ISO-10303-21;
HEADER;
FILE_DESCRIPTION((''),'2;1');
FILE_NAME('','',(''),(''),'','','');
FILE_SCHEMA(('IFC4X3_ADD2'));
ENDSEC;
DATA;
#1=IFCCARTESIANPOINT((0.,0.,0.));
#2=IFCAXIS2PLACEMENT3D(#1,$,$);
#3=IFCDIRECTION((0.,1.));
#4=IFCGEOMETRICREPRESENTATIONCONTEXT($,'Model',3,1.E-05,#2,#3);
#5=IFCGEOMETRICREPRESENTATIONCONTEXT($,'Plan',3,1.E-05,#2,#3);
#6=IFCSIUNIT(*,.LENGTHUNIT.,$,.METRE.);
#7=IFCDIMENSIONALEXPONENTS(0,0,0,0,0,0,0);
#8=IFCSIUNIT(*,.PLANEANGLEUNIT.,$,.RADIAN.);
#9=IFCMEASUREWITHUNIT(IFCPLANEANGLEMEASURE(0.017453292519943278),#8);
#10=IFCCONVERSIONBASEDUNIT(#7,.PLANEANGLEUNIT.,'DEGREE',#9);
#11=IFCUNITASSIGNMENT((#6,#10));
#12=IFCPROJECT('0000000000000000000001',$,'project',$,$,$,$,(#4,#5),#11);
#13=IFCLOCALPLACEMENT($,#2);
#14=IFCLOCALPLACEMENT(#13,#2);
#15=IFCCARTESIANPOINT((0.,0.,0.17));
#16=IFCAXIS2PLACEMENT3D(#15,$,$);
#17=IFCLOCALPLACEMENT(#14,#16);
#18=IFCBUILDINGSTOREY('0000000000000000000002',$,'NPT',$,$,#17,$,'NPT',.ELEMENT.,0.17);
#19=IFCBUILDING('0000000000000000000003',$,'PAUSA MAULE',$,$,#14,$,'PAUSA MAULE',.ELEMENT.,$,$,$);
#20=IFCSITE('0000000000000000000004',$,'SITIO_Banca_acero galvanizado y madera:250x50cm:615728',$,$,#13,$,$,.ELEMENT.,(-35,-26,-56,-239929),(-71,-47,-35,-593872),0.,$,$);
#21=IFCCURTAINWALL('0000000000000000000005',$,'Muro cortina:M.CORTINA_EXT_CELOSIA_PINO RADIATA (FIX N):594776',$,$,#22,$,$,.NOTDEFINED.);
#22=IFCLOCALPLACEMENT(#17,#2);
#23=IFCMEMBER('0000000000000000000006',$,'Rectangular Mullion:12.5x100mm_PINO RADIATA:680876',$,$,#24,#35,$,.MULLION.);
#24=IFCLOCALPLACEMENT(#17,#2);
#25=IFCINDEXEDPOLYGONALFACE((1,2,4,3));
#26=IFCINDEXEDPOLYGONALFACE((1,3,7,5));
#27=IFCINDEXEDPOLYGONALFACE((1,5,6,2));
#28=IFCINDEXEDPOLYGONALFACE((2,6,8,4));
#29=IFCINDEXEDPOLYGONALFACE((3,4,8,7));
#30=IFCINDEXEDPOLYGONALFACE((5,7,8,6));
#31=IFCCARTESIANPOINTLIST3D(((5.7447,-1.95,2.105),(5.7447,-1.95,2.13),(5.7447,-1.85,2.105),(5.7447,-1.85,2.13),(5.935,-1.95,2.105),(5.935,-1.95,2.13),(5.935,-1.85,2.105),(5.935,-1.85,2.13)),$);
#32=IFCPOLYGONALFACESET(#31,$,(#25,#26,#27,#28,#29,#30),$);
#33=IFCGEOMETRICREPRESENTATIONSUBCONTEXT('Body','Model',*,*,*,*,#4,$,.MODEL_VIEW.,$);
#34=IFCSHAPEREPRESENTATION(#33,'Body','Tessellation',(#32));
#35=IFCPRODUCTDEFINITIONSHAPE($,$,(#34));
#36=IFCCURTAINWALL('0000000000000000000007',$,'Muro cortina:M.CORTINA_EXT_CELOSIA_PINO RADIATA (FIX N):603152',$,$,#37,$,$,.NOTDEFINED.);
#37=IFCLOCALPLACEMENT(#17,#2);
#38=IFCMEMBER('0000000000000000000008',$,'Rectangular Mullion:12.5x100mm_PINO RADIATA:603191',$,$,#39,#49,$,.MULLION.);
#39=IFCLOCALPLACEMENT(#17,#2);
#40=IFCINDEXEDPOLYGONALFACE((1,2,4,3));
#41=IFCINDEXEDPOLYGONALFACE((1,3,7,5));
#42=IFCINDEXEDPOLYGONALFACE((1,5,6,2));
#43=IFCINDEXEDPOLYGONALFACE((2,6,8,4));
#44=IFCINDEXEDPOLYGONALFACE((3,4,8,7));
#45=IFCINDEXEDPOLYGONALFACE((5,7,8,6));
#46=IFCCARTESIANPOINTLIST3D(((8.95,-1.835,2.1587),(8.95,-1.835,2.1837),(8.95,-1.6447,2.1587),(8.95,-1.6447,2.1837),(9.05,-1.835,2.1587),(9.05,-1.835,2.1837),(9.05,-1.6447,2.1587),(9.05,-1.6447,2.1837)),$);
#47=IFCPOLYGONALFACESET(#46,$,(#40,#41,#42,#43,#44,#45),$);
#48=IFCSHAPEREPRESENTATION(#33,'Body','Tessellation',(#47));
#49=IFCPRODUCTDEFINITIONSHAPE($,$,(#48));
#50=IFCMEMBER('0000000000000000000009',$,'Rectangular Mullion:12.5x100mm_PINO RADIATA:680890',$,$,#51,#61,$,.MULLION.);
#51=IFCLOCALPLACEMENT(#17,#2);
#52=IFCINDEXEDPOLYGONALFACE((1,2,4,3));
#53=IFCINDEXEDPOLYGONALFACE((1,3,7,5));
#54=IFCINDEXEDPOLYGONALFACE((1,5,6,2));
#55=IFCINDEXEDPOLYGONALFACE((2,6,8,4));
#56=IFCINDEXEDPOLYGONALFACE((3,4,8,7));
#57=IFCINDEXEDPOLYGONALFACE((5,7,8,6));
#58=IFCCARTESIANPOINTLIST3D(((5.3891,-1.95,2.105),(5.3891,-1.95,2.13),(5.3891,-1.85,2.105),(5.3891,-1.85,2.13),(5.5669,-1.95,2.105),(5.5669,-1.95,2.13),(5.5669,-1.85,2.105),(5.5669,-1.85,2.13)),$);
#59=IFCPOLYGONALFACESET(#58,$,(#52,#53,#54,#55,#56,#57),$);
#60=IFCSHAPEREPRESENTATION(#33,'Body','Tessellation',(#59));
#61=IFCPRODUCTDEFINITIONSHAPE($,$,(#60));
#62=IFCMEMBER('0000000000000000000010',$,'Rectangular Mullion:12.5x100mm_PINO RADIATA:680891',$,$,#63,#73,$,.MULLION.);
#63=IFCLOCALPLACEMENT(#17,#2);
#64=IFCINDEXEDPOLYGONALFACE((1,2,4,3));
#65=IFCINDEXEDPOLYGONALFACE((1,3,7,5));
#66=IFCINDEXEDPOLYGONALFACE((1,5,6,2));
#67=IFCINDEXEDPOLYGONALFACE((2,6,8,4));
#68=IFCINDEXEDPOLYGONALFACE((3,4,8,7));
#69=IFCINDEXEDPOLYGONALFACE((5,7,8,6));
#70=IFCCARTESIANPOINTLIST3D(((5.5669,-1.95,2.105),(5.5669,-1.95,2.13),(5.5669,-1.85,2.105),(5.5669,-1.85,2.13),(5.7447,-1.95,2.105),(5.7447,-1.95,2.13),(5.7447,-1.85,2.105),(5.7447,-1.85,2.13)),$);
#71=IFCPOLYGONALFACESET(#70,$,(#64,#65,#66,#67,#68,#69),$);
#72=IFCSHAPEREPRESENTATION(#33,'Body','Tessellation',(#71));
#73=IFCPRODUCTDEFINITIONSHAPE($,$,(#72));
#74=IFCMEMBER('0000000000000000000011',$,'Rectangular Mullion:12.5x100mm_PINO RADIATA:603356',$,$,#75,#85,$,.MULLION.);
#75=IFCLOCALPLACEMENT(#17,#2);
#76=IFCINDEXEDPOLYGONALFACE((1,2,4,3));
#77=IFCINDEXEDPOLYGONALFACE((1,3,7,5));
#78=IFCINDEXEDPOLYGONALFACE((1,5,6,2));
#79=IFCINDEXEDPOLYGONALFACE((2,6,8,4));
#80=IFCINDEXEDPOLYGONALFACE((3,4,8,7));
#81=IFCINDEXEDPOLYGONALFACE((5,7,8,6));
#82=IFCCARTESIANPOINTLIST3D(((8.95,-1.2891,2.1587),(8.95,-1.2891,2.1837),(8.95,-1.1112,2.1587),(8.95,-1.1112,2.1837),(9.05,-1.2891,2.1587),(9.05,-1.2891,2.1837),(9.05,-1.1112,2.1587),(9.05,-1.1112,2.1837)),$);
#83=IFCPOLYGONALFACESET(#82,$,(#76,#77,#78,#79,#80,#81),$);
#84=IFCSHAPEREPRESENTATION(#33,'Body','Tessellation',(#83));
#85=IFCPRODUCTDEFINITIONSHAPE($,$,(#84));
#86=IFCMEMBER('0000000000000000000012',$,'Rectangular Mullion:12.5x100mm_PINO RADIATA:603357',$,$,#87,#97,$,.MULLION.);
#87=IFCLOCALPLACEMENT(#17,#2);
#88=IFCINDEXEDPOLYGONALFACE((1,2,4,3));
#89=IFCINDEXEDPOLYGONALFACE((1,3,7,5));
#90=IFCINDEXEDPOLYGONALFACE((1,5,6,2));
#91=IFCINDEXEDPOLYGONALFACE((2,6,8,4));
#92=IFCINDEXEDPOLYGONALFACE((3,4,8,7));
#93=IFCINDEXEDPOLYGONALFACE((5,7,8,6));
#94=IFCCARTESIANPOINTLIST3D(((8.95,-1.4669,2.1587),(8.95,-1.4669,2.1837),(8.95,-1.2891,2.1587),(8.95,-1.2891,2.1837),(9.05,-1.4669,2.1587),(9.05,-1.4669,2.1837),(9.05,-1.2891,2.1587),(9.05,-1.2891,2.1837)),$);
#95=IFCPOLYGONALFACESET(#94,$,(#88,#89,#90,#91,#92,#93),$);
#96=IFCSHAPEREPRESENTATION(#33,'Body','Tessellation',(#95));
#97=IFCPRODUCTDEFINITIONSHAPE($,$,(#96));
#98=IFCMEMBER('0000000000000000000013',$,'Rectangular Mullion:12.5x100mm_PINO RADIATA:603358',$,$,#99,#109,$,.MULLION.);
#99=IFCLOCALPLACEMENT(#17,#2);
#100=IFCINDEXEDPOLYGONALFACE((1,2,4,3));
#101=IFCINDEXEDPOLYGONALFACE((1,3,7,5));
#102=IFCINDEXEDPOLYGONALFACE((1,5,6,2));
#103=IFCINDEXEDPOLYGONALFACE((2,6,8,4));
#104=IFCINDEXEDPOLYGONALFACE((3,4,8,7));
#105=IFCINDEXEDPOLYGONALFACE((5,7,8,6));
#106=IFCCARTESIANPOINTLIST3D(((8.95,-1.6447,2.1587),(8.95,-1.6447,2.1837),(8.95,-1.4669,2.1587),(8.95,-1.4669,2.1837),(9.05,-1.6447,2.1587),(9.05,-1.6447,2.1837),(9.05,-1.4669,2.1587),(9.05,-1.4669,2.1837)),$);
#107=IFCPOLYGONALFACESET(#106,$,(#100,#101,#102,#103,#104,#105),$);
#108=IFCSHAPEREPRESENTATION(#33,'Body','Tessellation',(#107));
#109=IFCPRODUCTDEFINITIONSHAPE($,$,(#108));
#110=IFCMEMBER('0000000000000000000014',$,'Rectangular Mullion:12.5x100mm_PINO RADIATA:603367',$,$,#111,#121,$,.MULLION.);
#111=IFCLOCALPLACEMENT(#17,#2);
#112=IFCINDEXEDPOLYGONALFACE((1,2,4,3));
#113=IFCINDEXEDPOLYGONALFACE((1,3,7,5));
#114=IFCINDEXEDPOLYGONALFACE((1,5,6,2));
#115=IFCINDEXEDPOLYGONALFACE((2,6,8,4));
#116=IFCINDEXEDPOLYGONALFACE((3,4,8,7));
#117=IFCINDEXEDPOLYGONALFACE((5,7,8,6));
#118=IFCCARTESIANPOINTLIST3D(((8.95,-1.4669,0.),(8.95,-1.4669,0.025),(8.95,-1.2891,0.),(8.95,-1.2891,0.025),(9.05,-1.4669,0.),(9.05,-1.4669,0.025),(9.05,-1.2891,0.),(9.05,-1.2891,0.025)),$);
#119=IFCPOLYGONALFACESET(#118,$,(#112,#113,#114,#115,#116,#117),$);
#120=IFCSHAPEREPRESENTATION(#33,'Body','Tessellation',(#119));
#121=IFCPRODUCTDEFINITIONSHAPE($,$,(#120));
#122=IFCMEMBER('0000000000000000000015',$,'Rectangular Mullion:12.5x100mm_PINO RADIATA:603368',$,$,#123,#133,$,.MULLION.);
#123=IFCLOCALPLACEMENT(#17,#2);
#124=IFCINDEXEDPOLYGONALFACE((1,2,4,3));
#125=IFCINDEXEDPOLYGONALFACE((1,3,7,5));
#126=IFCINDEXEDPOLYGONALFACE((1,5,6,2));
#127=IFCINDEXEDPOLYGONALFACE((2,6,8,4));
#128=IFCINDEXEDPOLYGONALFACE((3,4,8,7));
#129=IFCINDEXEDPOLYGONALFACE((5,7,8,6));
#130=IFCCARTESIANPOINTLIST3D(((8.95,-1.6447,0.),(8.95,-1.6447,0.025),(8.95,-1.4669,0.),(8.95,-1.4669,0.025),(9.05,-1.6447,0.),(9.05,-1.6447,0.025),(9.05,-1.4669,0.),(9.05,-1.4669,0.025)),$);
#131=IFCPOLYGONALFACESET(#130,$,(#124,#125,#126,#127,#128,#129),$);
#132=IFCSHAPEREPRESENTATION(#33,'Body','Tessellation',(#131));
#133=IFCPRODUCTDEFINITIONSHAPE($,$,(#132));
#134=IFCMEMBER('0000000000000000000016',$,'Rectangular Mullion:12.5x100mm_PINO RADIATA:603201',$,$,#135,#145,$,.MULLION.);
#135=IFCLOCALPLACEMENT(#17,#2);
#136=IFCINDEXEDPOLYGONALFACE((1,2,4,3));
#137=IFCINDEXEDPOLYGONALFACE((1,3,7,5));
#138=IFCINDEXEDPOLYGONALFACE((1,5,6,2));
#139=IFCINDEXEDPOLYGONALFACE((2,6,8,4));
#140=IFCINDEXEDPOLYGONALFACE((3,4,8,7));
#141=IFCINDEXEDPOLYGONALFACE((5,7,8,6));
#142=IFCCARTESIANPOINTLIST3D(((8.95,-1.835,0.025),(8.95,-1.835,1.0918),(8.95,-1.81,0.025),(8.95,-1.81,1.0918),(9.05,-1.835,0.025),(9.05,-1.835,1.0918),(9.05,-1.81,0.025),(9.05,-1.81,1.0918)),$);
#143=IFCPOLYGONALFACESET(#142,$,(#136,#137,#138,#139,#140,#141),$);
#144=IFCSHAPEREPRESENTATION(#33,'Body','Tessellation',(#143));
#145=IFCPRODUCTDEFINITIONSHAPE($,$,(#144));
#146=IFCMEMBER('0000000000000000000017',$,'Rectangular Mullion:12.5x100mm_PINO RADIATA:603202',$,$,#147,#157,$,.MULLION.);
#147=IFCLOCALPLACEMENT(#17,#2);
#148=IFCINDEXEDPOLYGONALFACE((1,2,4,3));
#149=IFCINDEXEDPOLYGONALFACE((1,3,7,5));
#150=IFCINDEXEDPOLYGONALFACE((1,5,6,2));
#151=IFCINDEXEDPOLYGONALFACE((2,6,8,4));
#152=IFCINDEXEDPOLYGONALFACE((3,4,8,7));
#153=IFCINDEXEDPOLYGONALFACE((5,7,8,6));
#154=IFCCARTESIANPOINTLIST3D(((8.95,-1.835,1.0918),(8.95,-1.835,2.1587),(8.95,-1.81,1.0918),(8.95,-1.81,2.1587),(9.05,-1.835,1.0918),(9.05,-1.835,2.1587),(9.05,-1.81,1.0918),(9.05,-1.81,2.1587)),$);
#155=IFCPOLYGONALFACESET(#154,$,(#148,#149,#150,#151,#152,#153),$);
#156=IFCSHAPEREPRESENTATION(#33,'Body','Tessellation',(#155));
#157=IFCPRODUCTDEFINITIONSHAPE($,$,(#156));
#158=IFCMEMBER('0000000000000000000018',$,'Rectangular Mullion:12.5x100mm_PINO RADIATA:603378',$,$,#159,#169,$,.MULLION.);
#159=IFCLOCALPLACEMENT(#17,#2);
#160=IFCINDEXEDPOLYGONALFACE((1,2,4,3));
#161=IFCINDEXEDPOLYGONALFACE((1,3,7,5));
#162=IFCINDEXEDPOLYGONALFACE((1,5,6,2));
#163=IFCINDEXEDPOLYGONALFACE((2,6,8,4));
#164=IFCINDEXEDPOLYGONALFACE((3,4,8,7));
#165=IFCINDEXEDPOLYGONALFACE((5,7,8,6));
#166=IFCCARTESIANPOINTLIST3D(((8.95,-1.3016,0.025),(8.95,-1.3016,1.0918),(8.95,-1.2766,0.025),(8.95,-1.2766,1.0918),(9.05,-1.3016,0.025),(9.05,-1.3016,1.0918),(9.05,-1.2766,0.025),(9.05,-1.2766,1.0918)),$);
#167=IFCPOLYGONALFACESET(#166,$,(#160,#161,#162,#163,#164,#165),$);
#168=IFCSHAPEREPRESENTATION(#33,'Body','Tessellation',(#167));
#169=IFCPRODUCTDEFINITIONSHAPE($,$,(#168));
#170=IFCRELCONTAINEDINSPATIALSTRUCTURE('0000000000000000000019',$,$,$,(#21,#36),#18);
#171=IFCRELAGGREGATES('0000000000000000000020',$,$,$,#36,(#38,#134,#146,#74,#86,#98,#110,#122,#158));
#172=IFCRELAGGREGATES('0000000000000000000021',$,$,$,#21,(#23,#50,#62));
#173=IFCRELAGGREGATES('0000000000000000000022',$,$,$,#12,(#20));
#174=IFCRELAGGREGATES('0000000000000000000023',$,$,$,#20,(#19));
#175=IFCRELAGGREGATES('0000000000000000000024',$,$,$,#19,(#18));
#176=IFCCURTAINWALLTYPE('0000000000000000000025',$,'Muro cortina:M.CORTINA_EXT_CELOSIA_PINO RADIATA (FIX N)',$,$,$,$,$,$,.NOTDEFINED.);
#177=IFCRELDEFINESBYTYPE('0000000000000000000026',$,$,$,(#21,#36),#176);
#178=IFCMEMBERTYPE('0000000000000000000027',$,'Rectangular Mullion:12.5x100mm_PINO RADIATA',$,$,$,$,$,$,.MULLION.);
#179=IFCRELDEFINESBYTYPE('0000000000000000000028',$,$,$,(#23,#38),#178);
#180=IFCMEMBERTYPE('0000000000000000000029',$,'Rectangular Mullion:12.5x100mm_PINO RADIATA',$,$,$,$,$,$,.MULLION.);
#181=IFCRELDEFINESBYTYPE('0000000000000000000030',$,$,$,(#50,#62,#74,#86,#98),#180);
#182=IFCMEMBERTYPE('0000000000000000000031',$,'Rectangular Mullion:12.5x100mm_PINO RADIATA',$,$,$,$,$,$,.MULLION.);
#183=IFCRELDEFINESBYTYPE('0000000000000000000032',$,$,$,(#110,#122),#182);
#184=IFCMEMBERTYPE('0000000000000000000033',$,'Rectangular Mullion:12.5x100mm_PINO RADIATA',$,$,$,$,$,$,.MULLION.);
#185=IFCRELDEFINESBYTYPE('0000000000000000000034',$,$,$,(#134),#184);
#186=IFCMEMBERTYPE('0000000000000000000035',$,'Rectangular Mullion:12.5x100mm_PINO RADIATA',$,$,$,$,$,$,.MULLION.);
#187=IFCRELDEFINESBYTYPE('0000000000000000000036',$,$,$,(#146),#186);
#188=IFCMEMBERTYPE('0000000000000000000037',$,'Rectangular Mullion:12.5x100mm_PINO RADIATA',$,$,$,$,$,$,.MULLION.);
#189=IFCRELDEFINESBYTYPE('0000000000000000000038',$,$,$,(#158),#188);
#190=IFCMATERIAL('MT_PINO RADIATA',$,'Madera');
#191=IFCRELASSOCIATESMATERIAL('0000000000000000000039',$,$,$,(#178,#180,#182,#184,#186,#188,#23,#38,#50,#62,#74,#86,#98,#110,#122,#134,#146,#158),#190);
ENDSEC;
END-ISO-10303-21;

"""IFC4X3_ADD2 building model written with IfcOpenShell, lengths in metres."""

from ifc_helpers import new_model, entity, si_unit, converted_unit, direction, frame, frame_2d, origin, origin_2d_with_axis, place, context, subcontext, project, spatial, rectangle, extrude, source, transform, mapped, material, material_profile, profile_set, profile_usage, type_object, type_shapes, element, aggregate, save


model = new_model("IFC4X3_ADD2")

# Units and contexts
model_context = context("Model", 3, precision=1e-05, world=origin(), true_north=direction((0.0, 1.0)))
plan_context = context("Plan", 3, precision=1e-05, world=origin(), true_north=direction((0.0, 1.0)))
body_context = subcontext(model_context, "Body", "Model", "MODEL_VIEW")
ifc_project = project(units=[si_unit("LENGTHUNIT", "METRE"), converted_unit("PLANEANGLEUNIT", "DEGREE", entity("IfcPlaneAngleMeasure", 0.017453292519943278), si_unit("PLANEANGLEUNIT", "RADIAN"), dimensions=[0, 0, 0, 0, 0, 0, 0])], contexts=[model_context, plan_context])

# Site, building, storey
site_placement = place(None, origin())
site = spatial("IfcSite", under=ifc_project, at=site_placement, Name="SITIO_Banca_acero galvanizado y madera:250x50cm:615728", CompositionType="ELEMENT", RefLatitude=(-35, -26, -56, -239929), RefLongitude=(-71, -47, -35, -593872), RefElevation=0.0)
building_placement = place(site_placement, origin())
building = spatial("IfcBuilding", under=site, at=building_placement, Name="PAUSA MAULE", LongName="PAUSA MAULE", CompositionType="ELEMENT")
storey_placement = place(building_placement, frame((0.0, 0.0, 0.17)))
storey = spatial("IfcBuildingStorey", under=building, at=storey_placement, Name="NPT", LongName="NPT", CompositionType="ELEMENT", Elevation=0.17)

# Curtain walls, members
curtain_wall_type = type_object("IfcCurtainWallType", Name="Muro cortina:M.CORTINA_EXT_CELOSIA_PINO RADIATA (FIX N)", PredefinedType="NOTDEFINED")
curtain_wall_1_placement = place(storey_placement, frame((0.0, 0.0, -0.17)))
curtain_wall_1 = element("IfcCurtainWall", 1, at=curtain_wall_1_placement, inside=storey, type_object=curtain_wall_type, Name="Muro cortina:M.CORTINA_EXT_CELOSIA_PINO RADIATA (FIX N):594776", PredefinedType="NOTDEFINED")
ifc_material = material(Name="MT_PINO RADIATA", Category="Madera")
ifc_material_profile = material_profile(ifc_material, rectangle(XDim=0.025, YDim=0.1, at=frame_2d((0.0, 0.0), x_axis=(1.0, 0.0))), Name="12.5x100mm_PINO RADIATA")
ifc_profile_set = profile_set([ifc_material_profile], Name="12.5x100mm_PINO RADIATA")
ifc_profile_usage = profile_usage(ifc_profile_set)
member_type_1 = type_object("IfcMemberType", Name="Rectangular Mullion:12.5x100mm_PINO RADIATA", PredefinedType="MULLION", material=ifc_profile_set)
shared_shape_1 = source(origin(), body_context, "Body", "SweptSolid", [
    extrude(rectangle(XDim=0.025, YDim=0.1, at=frame_2d((0.0, 0.0), x_axis=(1.0, 0.0))), frame((-0.0125, 0.0, -0.1903), z_axis=(0.0, 0.0, 1.0), x_axis=(-1.0, 0.0, 0.0)), (0.0, 0.0, 1.0), 0.1903),
])
type_shapes(member_type_1, [shared_shape_1])
member_1_placement = place(curtain_wall_1_placement, frame((5.935, -1.9, 2.3), z_axis=(1.0, 0.0, 0.0), x_axis=(0.0, 0.0, 1.0)))
member_1 = element("IfcMember", 2, at=member_1_placement, type_object=member_type_1, material=ifc_profile_usage, Name="Rectangular Mullion:12.5x100mm_PINO RADIATA:680876", PredefinedType="MULLION", context=body_context, shape_type="MappedRepresentation", body=[
    mapped(shared_shape_1, transform((0.0, 0.0, 0.0), scale=1.0)),
])
curtain_wall_2_placement = place(storey_placement, frame((0.0, 0.0, -0.17)))
curtain_wall_2 = element("IfcCurtainWall", 3, at=curtain_wall_2_placement, inside=storey, type_object=curtain_wall_type, Name="Muro cortina:M.CORTINA_EXT_CELOSIA_PINO RADIATA (FIX N):603152", PredefinedType="NOTDEFINED")
member_2_placement = place(curtain_wall_2_placement, frame((9.0, -1.835, 2.3537), z_axis=(0.0, -1.0, 0.0), x_axis=(0.0, 0.0, 1.0)))
member_2 = element("IfcMember", 4, at=member_2_placement, type_object=member_type_1, material=ifc_profile_usage, Name="Rectangular Mullion:12.5x100mm_PINO RADIATA:603191", PredefinedType="MULLION", context=body_context, shape_type="MappedRepresentation", body=[
    mapped(shared_shape_1, transform((0.0, 0.0, 0.0), scale=1.0)),
])

# Members
member_type_2 = type_object("IfcMemberType", Name="Rectangular Mullion:12.5x100mm_PINO RADIATA", PredefinedType="MULLION", material=ifc_profile_set)
shared_shape_2 = source(origin(), body_context, "Body", "SweptSolid", [
    extrude(rectangle(XDim=0.025, YDim=0.1, at=frame_2d((0.0, 0.0), x_axis=(1.0, 0.0))), frame((-0.0125, 0.0, -0.1778), z_axis=(0.0, 0.0, 1.0), x_axis=(-1.0, 0.0, 0.0)), (0.0, 0.0, 1.0), 0.1778),
])
type_shapes(member_type_2, [shared_shape_2])
member_3_placement = place(curtain_wall_1_placement, frame((5.5669, -1.9, 2.3), z_axis=(1.0, 0.0, 0.0), x_axis=(0.0, 0.0, 1.0)))
member_3 = element("IfcMember", 5, at=member_3_placement, type_object=member_type_2, material=ifc_profile_usage, Name="Rectangular Mullion:12.5x100mm_PINO RADIATA:680890", PredefinedType="MULLION", context=body_context, shape_type="MappedRepresentation", body=[
    mapped(shared_shape_2, transform((0.0, 0.0, 0.0), scale=1.0)),
])
member_4_placement = place(curtain_wall_1_placement, frame((5.7447, -1.9, 2.3), z_axis=(1.0, 0.0, 0.0), x_axis=(0.0, 0.0, 1.0)))
member_4 = element("IfcMember", 6, at=member_4_placement, type_object=member_type_2, material=ifc_profile_usage, Name="Rectangular Mullion:12.5x100mm_PINO RADIATA:680891", PredefinedType="MULLION", context=body_context, shape_type="MappedRepresentation", body=[
    mapped(shared_shape_2, transform((0.0, 0.0, 0.0), scale=1.0)),
])
member_5_placement = place(curtain_wall_2_placement, frame((9.0, -1.2891, 2.3537), z_axis=(0.0, -1.0, 0.0), x_axis=(0.0, 0.0, 1.0)))
member_5 = element("IfcMember", 7, at=member_5_placement, type_object=member_type_2, material=ifc_profile_usage, Name="Rectangular Mullion:12.5x100mm_PINO RADIATA:603356", PredefinedType="MULLION", context=body_context, shape_type="MappedRepresentation", body=[
    mapped(shared_shape_2, transform((0.0, 0.0, 0.0), scale=1.0)),
])
member_6_placement = place(curtain_wall_2_placement, frame((9.0, -1.4669, 2.3537), z_axis=(0.0, -1.0, 0.0), x_axis=(0.0, 0.0, 1.0)))
member_6 = element("IfcMember", 8, at=member_6_placement, type_object=member_type_2, material=ifc_profile_usage, Name="Rectangular Mullion:12.5x100mm_PINO RADIATA:603357", PredefinedType="MULLION", context=body_context, shape_type="MappedRepresentation", body=[
    mapped(shared_shape_2, transform((0.0, 0.0, 0.0), scale=1.0)),
])
member_7_placement = place(curtain_wall_2_placement, frame((9.0, -1.6447, 2.3537), z_axis=(0.0, -1.0, 0.0), x_axis=(0.0, 0.0, 1.0)))
member_7 = element("IfcMember", 9, at=member_7_placement, type_object=member_type_2, material=ifc_profile_usage, Name="Rectangular Mullion:12.5x100mm_PINO RADIATA:603358", PredefinedType="MULLION", context=body_context, shape_type="MappedRepresentation", body=[
    mapped(shared_shape_2, transform((0.0, 0.0, 0.0), scale=1.0)),
])
member_type_3 = type_object("IfcMemberType", Name="Rectangular Mullion:12.5x100mm_PINO RADIATA", PredefinedType="MULLION", material=ifc_profile_set)
shared_shape_3 = source(origin(), body_context, "Body", "SweptSolid", [
    extrude(rectangle(XDim=0.025, YDim=0.1, at=frame_2d((0.0, 0.0), x_axis=(1.0, 0.0))), frame((-0.0125, 0.0, -0.1778), z_axis=(0.0, 0.0, 1.0), x_axis=(-1.0, 0.0, 0.0)), (0.0, 0.0, 1.0), 0.1778),
])
type_shapes(member_type_3, [shared_shape_3])
member_8_placement = place(curtain_wall_2_placement, frame((9.0, -1.2891, 0.17), z_axis=(0.0, 1.0, 0.0), x_axis=(0.0, 0.0, -1.0)))
member_8 = element("IfcMember", 10, at=member_8_placement, type_object=member_type_3, material=ifc_profile_usage, Name="Rectangular Mullion:12.5x100mm_PINO RADIATA:603367", PredefinedType="MULLION", context=body_context, shape_type="MappedRepresentation", body=[
    mapped(shared_shape_3, transform((0.0, 0.0, 0.0), scale=1.0)),
])
member_9_placement = place(curtain_wall_2_placement, frame((9.0, -1.4669, 0.17), z_axis=(0.0, 1.0, 0.0), x_axis=(0.0, 0.0, -1.0)))
member_9 = element("IfcMember", 11, at=member_9_placement, type_object=member_type_3, material=ifc_profile_usage, Name="Rectangular Mullion:12.5x100mm_PINO RADIATA:603368", PredefinedType="MULLION", context=body_context, shape_type="MappedRepresentation", body=[
    mapped(shared_shape_3, transform((0.0, 0.0, 0.0), scale=1.0)),
])
member_type_4 = type_object("IfcMemberType", Name="Rectangular Mullion:12.5x100mm_PINO RADIATA", PredefinedType="MULLION", material=ifc_profile_set)
shared_shape_4 = source(origin(), body_context, "Body", "SweptSolid", [
    extrude(rectangle(XDim=0.025, YDim=0.1, at=origin_2d_with_axis()), frame((-0.0125, 0.0, -1.0668), z_axis=(0.0, 0.0, 1.0), x_axis=(-1.0, 0.0, 0.0)), (0.0, 0.0, 1.0), 1.0668),
])
type_shapes(member_type_4, [shared_shape_4])
member_10_placement = place(curtain_wall_2_placement, frame((9.0, -1.835, 0.195), z_axis=(0.0, 0.0, -1.0), x_axis=(0.0, -1.0, 0.0)))
member_10 = element("IfcMember", 12, at=member_10_placement, type_object=member_type_4, material=ifc_profile_usage, Name="Rectangular Mullion:12.5x100mm_PINO RADIATA:603201", PredefinedType="MULLION", context=body_context, shape_type="MappedRepresentation", body=[
    mapped(shared_shape_4, transform((0.0, 0.0, 0.0), scale=1.0)),
])
member_type_5 = type_object("IfcMemberType", Name="Rectangular Mullion:12.5x100mm_PINO RADIATA", PredefinedType="MULLION", material=ifc_profile_set)
shared_shape_5 = source(origin(), body_context, "Body", "SweptSolid", [
    extrude(rectangle(XDim=0.025, YDim=0.1, at=frame_2d((0.0, 0.0), x_axis=(1.0, 0.0))), frame((-0.0125, 0.0, -1.0668), z_axis=(0.0, 0.0, 1.0), x_axis=(-1.0, 0.0, 0.0)), (0.0, 0.0, 1.0), 1.0668),
])
type_shapes(member_type_5, [shared_shape_5])
member_11_placement = place(curtain_wall_2_placement, frame((9.0, -1.835, 1.2618), z_axis=(0.0, 0.0, -1.0), x_axis=(0.0, -1.0, 0.0)))
member_11 = element("IfcMember", 13, at=member_11_placement, type_object=member_type_5, material=ifc_profile_usage, Name="Rectangular Mullion:12.5x100mm_PINO RADIATA:603202", PredefinedType="MULLION", context=body_context, shape_type="MappedRepresentation", body=[
    mapped(shared_shape_5, transform((0.0, 0.0, 0.0), scale=1.0)),
])
member_type_6 = type_object("IfcMemberType", Name="Rectangular Mullion:12.5x100mm_PINO RADIATA", PredefinedType="MULLION", material=ifc_profile_set)
shared_shape_6 = source(origin(), body_context, "Body", "SweptSolid", [
    extrude(rectangle(XDim=0.025, YDim=0.1, at=origin_2d_with_axis()), frame((0.0, 0.0, -1.0668), z_axis=(0.0, 0.0, 1.0), x_axis=(-1.0, 0.0, 0.0)), (0.0, 0.0, 1.0), 1.0668),
])
type_shapes(member_type_6, [shared_shape_6])
member_12_placement = place(curtain_wall_2_placement, frame((9.0, -1.2891, 0.195), z_axis=(0.0, 0.0, -1.0), x_axis=(0.0, -1.0, 0.0)))
member_12 = element("IfcMember", 14, at=member_12_placement, type_object=member_type_6, material=ifc_profile_usage, Name="Rectangular Mullion:12.5x100mm_PINO RADIATA:603378", PredefinedType="MULLION", context=body_context, shape_type="MappedRepresentation", body=[
    mapped(shared_shape_6, transform((0.0, 0.0, 0.0), scale=1.0)),
])
aggregate(curtain_wall_2, [member_2, member_10, member_11, member_5, member_6, member_7, member_8, member_9, member_12])

aggregate(curtain_wall_1, [member_1, member_3, member_4])

save(model, "model.ifc")
